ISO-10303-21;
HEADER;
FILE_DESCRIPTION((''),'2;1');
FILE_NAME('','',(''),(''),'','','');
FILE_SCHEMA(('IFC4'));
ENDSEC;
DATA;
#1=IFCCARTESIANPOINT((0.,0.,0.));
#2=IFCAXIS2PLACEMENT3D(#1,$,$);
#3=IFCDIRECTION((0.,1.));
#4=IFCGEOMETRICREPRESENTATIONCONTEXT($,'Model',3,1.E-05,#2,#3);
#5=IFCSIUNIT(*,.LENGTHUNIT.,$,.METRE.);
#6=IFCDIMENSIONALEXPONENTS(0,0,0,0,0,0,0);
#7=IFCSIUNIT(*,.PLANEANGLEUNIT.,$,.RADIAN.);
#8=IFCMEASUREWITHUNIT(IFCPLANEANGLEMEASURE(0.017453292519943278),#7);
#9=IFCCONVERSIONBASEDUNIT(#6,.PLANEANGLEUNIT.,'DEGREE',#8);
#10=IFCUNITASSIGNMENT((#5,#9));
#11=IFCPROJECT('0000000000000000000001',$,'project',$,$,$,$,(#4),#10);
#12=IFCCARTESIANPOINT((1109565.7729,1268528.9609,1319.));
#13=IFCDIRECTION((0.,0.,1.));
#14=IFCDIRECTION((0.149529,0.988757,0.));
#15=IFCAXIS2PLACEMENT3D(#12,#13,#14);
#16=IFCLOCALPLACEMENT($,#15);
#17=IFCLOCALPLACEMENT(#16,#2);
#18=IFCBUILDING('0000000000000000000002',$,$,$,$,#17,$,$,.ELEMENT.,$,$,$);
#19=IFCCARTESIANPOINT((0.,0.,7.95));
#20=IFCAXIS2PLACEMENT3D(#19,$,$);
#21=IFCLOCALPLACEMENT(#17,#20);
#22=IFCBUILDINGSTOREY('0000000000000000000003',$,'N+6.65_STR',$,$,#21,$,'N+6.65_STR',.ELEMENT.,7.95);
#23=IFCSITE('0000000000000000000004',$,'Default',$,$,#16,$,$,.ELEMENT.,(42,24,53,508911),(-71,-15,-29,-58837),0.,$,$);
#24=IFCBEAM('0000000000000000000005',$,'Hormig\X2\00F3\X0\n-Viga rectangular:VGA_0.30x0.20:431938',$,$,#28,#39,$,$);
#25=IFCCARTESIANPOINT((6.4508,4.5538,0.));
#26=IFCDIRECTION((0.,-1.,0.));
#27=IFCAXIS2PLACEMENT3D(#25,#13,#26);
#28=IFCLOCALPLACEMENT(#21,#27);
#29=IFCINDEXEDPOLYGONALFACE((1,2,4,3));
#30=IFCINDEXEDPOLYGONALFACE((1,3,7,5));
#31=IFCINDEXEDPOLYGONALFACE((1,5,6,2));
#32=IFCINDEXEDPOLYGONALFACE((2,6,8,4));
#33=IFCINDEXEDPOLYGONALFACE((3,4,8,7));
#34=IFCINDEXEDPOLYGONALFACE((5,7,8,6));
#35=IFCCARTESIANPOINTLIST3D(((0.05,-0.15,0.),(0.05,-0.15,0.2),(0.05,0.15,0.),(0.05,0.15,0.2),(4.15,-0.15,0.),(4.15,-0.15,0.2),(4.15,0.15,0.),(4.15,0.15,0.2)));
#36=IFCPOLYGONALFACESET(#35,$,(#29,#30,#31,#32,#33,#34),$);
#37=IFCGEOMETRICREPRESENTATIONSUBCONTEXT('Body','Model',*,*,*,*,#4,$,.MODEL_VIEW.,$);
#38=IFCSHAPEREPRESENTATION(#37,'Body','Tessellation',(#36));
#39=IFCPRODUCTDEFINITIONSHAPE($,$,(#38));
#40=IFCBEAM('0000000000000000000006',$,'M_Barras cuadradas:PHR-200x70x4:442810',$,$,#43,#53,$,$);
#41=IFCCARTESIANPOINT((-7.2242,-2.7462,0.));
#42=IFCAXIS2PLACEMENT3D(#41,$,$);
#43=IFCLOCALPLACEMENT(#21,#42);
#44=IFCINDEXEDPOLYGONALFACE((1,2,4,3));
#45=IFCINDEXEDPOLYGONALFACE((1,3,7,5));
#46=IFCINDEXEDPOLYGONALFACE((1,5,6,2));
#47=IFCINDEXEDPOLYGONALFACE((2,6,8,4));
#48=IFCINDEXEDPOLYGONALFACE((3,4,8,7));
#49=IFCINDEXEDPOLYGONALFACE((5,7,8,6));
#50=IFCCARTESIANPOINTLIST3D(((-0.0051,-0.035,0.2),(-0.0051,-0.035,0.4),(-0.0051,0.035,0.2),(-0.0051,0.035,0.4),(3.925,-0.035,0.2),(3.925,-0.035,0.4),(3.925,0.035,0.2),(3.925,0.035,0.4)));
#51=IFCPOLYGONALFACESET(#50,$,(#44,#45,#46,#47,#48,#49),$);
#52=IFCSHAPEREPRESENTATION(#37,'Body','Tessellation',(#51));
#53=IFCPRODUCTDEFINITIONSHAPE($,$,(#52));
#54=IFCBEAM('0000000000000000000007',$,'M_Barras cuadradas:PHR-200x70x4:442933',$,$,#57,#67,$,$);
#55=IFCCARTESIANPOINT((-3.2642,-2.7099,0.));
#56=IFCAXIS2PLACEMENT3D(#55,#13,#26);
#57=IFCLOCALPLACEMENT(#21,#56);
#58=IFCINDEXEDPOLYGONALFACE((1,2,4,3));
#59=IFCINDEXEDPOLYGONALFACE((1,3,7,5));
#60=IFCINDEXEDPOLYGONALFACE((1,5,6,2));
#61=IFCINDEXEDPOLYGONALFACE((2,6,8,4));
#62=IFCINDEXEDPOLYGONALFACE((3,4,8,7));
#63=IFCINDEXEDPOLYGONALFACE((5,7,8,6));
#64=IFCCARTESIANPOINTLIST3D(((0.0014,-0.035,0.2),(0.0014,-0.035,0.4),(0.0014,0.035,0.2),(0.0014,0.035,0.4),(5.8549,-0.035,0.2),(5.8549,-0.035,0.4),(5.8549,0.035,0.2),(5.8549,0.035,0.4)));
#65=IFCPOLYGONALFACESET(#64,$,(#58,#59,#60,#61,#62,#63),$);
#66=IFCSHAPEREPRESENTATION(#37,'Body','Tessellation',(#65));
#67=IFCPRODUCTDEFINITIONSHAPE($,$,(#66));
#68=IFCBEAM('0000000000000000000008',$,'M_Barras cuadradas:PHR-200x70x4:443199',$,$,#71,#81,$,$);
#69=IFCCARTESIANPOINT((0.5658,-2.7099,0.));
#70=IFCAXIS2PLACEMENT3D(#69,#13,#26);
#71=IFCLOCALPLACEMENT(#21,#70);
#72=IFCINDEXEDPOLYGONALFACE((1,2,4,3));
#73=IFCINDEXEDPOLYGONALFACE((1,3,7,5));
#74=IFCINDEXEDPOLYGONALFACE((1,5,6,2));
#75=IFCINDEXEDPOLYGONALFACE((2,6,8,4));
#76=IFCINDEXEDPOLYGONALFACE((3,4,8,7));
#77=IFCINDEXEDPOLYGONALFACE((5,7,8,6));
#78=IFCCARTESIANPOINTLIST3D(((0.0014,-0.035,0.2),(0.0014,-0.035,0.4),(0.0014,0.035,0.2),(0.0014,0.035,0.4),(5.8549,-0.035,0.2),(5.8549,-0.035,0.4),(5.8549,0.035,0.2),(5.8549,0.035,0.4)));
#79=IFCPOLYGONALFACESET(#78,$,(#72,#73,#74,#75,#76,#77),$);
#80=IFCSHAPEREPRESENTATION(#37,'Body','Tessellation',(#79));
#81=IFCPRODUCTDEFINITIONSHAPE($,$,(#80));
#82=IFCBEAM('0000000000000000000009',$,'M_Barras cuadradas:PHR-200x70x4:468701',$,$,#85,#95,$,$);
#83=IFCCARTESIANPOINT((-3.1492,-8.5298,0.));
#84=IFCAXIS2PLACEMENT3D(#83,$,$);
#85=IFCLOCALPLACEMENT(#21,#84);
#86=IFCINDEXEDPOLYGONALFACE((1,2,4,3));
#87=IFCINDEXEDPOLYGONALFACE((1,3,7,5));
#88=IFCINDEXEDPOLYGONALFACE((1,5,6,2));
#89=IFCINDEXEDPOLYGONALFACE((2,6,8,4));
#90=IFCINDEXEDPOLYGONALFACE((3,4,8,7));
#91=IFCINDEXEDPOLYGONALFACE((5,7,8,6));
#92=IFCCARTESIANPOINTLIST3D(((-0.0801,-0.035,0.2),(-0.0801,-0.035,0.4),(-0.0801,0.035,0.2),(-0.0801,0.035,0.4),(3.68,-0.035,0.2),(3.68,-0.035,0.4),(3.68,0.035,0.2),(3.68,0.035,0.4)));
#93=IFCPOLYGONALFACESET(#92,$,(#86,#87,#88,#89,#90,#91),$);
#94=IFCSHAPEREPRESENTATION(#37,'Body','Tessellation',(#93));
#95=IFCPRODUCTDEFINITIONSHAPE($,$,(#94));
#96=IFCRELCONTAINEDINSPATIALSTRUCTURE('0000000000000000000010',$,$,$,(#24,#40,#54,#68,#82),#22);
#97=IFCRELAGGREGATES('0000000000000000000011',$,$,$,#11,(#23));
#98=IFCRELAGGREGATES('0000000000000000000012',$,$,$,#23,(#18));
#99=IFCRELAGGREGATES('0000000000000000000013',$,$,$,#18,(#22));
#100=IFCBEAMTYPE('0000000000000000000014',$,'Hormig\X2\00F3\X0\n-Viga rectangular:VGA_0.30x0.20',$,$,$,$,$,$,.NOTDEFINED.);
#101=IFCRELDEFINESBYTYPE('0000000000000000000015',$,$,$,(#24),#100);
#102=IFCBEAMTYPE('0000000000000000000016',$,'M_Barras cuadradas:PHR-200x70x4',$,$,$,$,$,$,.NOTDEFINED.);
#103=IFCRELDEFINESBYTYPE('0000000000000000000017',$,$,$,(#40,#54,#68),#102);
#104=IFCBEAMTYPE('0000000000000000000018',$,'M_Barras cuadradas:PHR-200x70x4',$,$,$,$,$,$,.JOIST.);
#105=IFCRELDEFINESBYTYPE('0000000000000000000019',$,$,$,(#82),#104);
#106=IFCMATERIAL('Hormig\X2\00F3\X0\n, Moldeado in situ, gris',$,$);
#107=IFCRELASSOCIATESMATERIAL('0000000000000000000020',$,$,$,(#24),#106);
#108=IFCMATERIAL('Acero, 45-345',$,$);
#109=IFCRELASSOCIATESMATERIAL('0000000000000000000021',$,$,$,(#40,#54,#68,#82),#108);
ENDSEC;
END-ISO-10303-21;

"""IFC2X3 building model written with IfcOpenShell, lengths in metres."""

from ifc_helpers import new_model, entity, si_unit, converted_unit, direction, frame, frame_2d, origin, place, context, subcontext, project, spatial, rectangle, extrude, material, type_object, element, save


model = new_model("IFC2X3")

# Units and contexts
model_context = context("Model", 3, precision=1e-05, world=origin(), true_north=direction((0.0, 1.0)))
body_context = subcontext(model_context, "Body", "Model", "MODEL_VIEW")
ifc_project = project(units=[si_unit("LENGTHUNIT", "METRE"), converted_unit("PLANEANGLEUNIT", "DEGREE", entity("IfcPlaneAngleMeasure", 0.017453292519943278), si_unit("PLANEANGLEUNIT", "RADIAN"), dimensions=[0, 0, 0, 0, 0, 0, 0])], contexts=[model_context])

# Site, building, storey
site_placement = place(None, frame((1109565.7729, 1268528.9609, 1319.0), z_axis=(0.0, 0.0, 1.0), x_axis=(0.149529, 0.988757, 0.0)))
site = spatial("IfcSite", under=ifc_project, at=site_placement, Name="Default", CompositionType="ELEMENT", RefLatitude=(42, 24, 53, 508911), RefLongitude=(-71, -15, -29, -58837), RefElevation=0.0)
building_placement = place(site_placement, origin())
building = spatial("IfcBuilding", under=site, at=building_placement, CompositionType="ELEMENT")
storey_placement = place(building_placement, frame((0.0, 0.0, 7.95)))
storey = spatial("IfcBuildingStorey", under=building, at=storey_placement, Name="N+6.65_STR", LongName="N+6.65_STR", CompositionType="ELEMENT", Elevation=7.95)

# Beams
ifc_material_1 = material(Name="Hormigón, Moldeado in situ, gris")
beam_type_1 = type_object("IfcBeamType", Name="Hormigón-Viga rectangular:VGA_0.30x0.20", PredefinedType="NOTDEFINED")
beam_1_placement = place(storey_placement, frame((6.4508, 4.5538, 0.0), z_axis=(0.0, 0.0, 1.0), x_axis=(0.0, -1.0, 0.0)))
element("IfcBeam", 1, at=beam_1_placement, inside=storey, type_object=beam_type_1, material=ifc_material_1, Name="Hormigón-Viga rectangular:VGA_0.30x0.20:431938", context=body_context, shape_type="SweptSolid", body=[
    extrude(rectangle(XDim=0.2, YDim=0.3, at=frame_2d((0.0, 0.0), x_axis=(1.0, 0.0))), frame((0.05, 0.0, 0.1), z_axis=(1.0, 0.0, 0.0), x_axis=(0.0, 0.0, -1.0)), (0.0, 0.0, 1.0), 4.1),
])
ifc_material_2 = material(Name="Acero, 45-345")
beam_type_2 = type_object("IfcBeamType", Name="M_Barras cuadradas:PHR-200x70x4", PredefinedType="NOTDEFINED")
beam_2_placement = place(storey_placement, frame((-7.2242, -2.7462, 0.0)))
element("IfcBeam", 2, at=beam_2_placement, inside=storey, type_object=beam_type_2, material=ifc_material_2, Name="M_Barras cuadradas:PHR-200x70x4:442810", context=body_context, shape_type="SweptSolid", body=[
    extrude(rectangle(XDim=0.2, YDim=0.07, at=frame_2d((0.0, 0.0), x_axis=(1.0, 0.0))), frame((-0.0051, 0.0, 0.3), z_axis=(1.0, 0.0, 0.0), x_axis=(0.0, 0.0, -1.0)), (0.0, 0.0, 1.0), 3.9301),
])
beam_3_placement = place(storey_placement, frame((-3.2642, -2.7099, 0.0), z_axis=(0.0, 0.0, 1.0), x_axis=(0.0, -1.0, 0.0)))
element("IfcBeam", 3, at=beam_3_placement, inside=storey, type_object=beam_type_2, material=ifc_material_2, Name="M_Barras cuadradas:PHR-200x70x4:442933", context=body_context, shape_type="SweptSolid", body=[
    extrude(rectangle(XDim=0.2, YDim=0.07, at=frame_2d((0.0, 0.0), x_axis=(1.0, 0.0))), frame((0.0014, 0.0, 0.3), z_axis=(1.0, 0.0, 0.0), x_axis=(0.0, 0.0, -1.0)), (0.0, 0.0, 1.0), 5.8535),
])
beam_4_placement = place(storey_placement, frame((0.5658, -2.7099, 0.0), z_axis=(0.0, 0.0, 1.0), x_axis=(0.0, -1.0, 0.0)))
element("IfcBeam", 4, at=beam_4_placement, inside=storey, type_object=beam_type_2, material=ifc_material_2, Name="M_Barras cuadradas:PHR-200x70x4:443199", context=body_context, shape_type="SweptSolid", body=[
    extrude(rectangle(XDim=0.2, YDim=0.07, at=frame_2d((0.0, 0.0), x_axis=(1.0, 0.0))), frame((0.0014, 0.0, 0.3), z_axis=(1.0, 0.0, 0.0), x_axis=(0.0, 0.0, -1.0)), (0.0, 0.0, 1.0), 5.8535),
])
beam_type_3 = type_object("IfcBeamType", Name="M_Barras cuadradas:PHR-200x70x4", PredefinedType="JOIST")
beam_5_placement = place(storey_placement, frame((-3.1492, -8.5298, 0.0)))
element("IfcBeam", 5, at=beam_5_placement, inside=storey, type_object=beam_type_3, material=ifc_material_2, Name="M_Barras cuadradas:PHR-200x70x4:468701", context=body_context, shape_type="SweptSolid", body=[
    extrude(rectangle(XDim=0.2, YDim=0.07, at=frame_2d((0.0, 0.0), x_axis=(1.0, 0.0))), frame((-0.0801, 0.0, 0.3), z_axis=(1.0, 0.0, 0.0), x_axis=(0.0, 0.0, -1.0)), (0.0, 0.0, 1.0), 3.7601),
])

save(model, "model.ifc")
